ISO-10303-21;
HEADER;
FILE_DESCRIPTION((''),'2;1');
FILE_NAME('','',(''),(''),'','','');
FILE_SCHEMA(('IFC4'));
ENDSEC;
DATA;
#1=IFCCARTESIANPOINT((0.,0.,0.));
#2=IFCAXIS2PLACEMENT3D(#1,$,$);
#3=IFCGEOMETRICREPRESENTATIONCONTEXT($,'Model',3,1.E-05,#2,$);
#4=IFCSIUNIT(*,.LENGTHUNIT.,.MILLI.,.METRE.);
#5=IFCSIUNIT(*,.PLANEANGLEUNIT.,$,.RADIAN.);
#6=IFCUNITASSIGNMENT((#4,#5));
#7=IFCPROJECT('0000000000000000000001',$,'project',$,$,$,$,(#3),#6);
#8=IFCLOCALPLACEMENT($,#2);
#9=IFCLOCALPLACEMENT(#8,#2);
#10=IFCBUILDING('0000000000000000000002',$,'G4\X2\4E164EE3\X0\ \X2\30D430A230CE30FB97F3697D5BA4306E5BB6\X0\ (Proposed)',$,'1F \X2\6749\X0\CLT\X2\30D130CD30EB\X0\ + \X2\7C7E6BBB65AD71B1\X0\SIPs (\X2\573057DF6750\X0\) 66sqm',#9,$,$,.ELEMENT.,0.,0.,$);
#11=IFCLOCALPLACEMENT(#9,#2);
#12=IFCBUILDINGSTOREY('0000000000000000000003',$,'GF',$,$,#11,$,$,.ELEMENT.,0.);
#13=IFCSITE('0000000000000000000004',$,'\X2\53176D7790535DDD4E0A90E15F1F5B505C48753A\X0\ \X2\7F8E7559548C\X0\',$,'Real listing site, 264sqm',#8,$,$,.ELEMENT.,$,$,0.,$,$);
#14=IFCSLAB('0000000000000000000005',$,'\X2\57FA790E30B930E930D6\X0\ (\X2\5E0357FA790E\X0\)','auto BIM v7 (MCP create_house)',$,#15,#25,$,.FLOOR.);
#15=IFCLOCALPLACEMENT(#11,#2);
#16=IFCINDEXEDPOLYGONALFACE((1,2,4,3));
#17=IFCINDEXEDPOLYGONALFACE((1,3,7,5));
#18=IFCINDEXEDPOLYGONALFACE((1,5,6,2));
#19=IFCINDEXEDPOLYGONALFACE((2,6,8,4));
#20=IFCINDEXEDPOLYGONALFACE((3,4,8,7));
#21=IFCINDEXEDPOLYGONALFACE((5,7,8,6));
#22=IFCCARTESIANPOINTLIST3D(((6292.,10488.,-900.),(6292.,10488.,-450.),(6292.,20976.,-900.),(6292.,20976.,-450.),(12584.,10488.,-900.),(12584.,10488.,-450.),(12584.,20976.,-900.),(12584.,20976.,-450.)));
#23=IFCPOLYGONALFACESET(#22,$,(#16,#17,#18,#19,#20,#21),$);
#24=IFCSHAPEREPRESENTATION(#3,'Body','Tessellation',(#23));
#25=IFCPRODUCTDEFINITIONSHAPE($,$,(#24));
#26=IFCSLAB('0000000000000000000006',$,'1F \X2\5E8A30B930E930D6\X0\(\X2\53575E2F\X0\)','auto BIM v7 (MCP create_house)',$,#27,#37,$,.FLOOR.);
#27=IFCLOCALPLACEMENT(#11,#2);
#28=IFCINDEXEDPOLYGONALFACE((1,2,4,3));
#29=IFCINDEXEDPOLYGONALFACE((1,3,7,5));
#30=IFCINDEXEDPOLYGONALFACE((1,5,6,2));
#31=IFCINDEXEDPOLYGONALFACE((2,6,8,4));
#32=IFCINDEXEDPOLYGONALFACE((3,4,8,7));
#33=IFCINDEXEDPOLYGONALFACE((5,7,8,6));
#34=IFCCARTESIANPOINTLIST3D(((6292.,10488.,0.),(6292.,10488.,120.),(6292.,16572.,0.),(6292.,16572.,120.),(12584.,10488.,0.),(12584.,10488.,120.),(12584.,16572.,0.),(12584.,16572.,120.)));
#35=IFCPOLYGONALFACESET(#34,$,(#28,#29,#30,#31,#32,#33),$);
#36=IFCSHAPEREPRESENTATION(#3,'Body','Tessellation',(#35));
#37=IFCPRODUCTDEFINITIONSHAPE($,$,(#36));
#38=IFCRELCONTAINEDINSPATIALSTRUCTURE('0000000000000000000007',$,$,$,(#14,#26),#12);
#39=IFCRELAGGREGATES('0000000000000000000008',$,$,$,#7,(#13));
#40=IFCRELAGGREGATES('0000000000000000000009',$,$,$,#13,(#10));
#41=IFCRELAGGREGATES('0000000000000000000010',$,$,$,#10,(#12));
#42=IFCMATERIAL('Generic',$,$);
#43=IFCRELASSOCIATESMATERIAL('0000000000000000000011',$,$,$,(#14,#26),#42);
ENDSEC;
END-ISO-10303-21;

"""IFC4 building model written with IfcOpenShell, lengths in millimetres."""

from ifc_helpers import new_model, si_unit, frame, frame_2d, origin, place, context, project, spatial, rectangle, extrude, material, element, save


model = new_model("IFC4")

# Units and contexts
model_context = context("Model", 3, precision=1e-05, world=origin())
ifc_project = project(units=[si_unit("LENGTHUNIT", "METRE", prefix="MILLI"), si_unit("PLANEANGLEUNIT", "RADIAN")], contexts=[model_context])

# Site, building, storey
site_placement = place(None, origin())
site = spatial("IfcSite", under=ifc_project, at=site_placement, Name="北海道川上郡弟子屈町 美留和", ObjectType="Real listing site, 264sqm", CompositionType="ELEMENT", RefElevation=0.0)
building_placement = place(site_placement, origin())
building = spatial("IfcBuilding", under=site, at=building_placement, Name="G4世代 ピアノ・音楽室の家 (Proposed)", ObjectType="1F 杉CLTパネル + 籾殻断熱SIPs (地域材) 66sqm", CompositionType="ELEMENT", ElevationOfRefHeight=0.0, ElevationOfTerrain=0.0)
storey_placement = place(building_placement, origin())
storey = spatial("IfcBuildingStorey", under=building, at=storey_placement, Name="GF", CompositionType="ELEMENT", Elevation=0.0)

# Slabs
ifc_material = material(Name="Generic")
slab_1_placement = place(storey_placement, frame((3146.0, 5244.0, -450.0)))
element("IfcSlab", 1, at=slab_1_placement, inside=storey, material=ifc_material, Name="基礎スラブ (布基礎)", Description="auto BIM v7 (MCP create_house)", PredefinedType="FLOOR", context=model_context, shape_type="SweptSolid", body=[
    extrude(rectangle(XDim=6292.0, YDim=10488.0, at=frame_2d((3146.0, 5244.0))), frame((3146.0, 5244.0, -450.0)), (0.0, 0.0, 1.0), 450.0),
])
slab_2_placement = place(storey_placement, frame((3146.0, 5244.0, 0.0)))
element("IfcSlab", 2, at=slab_2_placement, inside=storey, material=ifc_material, Name="1F 床スラブ(南帯)", Description="auto BIM v7 (MCP create_house)", PredefinedType="FLOOR", context=model_context, shape_type="SweptSolid", body=[
    extrude(rectangle(XDim=6292.0, YDim=6084.0, at=frame_2d((3146.0, 3042.0))), frame((3146.0, 5244.0, 0.0)), (0.0, 0.0, 1.0), 120.0),
])

save(model, "model.ifc")
